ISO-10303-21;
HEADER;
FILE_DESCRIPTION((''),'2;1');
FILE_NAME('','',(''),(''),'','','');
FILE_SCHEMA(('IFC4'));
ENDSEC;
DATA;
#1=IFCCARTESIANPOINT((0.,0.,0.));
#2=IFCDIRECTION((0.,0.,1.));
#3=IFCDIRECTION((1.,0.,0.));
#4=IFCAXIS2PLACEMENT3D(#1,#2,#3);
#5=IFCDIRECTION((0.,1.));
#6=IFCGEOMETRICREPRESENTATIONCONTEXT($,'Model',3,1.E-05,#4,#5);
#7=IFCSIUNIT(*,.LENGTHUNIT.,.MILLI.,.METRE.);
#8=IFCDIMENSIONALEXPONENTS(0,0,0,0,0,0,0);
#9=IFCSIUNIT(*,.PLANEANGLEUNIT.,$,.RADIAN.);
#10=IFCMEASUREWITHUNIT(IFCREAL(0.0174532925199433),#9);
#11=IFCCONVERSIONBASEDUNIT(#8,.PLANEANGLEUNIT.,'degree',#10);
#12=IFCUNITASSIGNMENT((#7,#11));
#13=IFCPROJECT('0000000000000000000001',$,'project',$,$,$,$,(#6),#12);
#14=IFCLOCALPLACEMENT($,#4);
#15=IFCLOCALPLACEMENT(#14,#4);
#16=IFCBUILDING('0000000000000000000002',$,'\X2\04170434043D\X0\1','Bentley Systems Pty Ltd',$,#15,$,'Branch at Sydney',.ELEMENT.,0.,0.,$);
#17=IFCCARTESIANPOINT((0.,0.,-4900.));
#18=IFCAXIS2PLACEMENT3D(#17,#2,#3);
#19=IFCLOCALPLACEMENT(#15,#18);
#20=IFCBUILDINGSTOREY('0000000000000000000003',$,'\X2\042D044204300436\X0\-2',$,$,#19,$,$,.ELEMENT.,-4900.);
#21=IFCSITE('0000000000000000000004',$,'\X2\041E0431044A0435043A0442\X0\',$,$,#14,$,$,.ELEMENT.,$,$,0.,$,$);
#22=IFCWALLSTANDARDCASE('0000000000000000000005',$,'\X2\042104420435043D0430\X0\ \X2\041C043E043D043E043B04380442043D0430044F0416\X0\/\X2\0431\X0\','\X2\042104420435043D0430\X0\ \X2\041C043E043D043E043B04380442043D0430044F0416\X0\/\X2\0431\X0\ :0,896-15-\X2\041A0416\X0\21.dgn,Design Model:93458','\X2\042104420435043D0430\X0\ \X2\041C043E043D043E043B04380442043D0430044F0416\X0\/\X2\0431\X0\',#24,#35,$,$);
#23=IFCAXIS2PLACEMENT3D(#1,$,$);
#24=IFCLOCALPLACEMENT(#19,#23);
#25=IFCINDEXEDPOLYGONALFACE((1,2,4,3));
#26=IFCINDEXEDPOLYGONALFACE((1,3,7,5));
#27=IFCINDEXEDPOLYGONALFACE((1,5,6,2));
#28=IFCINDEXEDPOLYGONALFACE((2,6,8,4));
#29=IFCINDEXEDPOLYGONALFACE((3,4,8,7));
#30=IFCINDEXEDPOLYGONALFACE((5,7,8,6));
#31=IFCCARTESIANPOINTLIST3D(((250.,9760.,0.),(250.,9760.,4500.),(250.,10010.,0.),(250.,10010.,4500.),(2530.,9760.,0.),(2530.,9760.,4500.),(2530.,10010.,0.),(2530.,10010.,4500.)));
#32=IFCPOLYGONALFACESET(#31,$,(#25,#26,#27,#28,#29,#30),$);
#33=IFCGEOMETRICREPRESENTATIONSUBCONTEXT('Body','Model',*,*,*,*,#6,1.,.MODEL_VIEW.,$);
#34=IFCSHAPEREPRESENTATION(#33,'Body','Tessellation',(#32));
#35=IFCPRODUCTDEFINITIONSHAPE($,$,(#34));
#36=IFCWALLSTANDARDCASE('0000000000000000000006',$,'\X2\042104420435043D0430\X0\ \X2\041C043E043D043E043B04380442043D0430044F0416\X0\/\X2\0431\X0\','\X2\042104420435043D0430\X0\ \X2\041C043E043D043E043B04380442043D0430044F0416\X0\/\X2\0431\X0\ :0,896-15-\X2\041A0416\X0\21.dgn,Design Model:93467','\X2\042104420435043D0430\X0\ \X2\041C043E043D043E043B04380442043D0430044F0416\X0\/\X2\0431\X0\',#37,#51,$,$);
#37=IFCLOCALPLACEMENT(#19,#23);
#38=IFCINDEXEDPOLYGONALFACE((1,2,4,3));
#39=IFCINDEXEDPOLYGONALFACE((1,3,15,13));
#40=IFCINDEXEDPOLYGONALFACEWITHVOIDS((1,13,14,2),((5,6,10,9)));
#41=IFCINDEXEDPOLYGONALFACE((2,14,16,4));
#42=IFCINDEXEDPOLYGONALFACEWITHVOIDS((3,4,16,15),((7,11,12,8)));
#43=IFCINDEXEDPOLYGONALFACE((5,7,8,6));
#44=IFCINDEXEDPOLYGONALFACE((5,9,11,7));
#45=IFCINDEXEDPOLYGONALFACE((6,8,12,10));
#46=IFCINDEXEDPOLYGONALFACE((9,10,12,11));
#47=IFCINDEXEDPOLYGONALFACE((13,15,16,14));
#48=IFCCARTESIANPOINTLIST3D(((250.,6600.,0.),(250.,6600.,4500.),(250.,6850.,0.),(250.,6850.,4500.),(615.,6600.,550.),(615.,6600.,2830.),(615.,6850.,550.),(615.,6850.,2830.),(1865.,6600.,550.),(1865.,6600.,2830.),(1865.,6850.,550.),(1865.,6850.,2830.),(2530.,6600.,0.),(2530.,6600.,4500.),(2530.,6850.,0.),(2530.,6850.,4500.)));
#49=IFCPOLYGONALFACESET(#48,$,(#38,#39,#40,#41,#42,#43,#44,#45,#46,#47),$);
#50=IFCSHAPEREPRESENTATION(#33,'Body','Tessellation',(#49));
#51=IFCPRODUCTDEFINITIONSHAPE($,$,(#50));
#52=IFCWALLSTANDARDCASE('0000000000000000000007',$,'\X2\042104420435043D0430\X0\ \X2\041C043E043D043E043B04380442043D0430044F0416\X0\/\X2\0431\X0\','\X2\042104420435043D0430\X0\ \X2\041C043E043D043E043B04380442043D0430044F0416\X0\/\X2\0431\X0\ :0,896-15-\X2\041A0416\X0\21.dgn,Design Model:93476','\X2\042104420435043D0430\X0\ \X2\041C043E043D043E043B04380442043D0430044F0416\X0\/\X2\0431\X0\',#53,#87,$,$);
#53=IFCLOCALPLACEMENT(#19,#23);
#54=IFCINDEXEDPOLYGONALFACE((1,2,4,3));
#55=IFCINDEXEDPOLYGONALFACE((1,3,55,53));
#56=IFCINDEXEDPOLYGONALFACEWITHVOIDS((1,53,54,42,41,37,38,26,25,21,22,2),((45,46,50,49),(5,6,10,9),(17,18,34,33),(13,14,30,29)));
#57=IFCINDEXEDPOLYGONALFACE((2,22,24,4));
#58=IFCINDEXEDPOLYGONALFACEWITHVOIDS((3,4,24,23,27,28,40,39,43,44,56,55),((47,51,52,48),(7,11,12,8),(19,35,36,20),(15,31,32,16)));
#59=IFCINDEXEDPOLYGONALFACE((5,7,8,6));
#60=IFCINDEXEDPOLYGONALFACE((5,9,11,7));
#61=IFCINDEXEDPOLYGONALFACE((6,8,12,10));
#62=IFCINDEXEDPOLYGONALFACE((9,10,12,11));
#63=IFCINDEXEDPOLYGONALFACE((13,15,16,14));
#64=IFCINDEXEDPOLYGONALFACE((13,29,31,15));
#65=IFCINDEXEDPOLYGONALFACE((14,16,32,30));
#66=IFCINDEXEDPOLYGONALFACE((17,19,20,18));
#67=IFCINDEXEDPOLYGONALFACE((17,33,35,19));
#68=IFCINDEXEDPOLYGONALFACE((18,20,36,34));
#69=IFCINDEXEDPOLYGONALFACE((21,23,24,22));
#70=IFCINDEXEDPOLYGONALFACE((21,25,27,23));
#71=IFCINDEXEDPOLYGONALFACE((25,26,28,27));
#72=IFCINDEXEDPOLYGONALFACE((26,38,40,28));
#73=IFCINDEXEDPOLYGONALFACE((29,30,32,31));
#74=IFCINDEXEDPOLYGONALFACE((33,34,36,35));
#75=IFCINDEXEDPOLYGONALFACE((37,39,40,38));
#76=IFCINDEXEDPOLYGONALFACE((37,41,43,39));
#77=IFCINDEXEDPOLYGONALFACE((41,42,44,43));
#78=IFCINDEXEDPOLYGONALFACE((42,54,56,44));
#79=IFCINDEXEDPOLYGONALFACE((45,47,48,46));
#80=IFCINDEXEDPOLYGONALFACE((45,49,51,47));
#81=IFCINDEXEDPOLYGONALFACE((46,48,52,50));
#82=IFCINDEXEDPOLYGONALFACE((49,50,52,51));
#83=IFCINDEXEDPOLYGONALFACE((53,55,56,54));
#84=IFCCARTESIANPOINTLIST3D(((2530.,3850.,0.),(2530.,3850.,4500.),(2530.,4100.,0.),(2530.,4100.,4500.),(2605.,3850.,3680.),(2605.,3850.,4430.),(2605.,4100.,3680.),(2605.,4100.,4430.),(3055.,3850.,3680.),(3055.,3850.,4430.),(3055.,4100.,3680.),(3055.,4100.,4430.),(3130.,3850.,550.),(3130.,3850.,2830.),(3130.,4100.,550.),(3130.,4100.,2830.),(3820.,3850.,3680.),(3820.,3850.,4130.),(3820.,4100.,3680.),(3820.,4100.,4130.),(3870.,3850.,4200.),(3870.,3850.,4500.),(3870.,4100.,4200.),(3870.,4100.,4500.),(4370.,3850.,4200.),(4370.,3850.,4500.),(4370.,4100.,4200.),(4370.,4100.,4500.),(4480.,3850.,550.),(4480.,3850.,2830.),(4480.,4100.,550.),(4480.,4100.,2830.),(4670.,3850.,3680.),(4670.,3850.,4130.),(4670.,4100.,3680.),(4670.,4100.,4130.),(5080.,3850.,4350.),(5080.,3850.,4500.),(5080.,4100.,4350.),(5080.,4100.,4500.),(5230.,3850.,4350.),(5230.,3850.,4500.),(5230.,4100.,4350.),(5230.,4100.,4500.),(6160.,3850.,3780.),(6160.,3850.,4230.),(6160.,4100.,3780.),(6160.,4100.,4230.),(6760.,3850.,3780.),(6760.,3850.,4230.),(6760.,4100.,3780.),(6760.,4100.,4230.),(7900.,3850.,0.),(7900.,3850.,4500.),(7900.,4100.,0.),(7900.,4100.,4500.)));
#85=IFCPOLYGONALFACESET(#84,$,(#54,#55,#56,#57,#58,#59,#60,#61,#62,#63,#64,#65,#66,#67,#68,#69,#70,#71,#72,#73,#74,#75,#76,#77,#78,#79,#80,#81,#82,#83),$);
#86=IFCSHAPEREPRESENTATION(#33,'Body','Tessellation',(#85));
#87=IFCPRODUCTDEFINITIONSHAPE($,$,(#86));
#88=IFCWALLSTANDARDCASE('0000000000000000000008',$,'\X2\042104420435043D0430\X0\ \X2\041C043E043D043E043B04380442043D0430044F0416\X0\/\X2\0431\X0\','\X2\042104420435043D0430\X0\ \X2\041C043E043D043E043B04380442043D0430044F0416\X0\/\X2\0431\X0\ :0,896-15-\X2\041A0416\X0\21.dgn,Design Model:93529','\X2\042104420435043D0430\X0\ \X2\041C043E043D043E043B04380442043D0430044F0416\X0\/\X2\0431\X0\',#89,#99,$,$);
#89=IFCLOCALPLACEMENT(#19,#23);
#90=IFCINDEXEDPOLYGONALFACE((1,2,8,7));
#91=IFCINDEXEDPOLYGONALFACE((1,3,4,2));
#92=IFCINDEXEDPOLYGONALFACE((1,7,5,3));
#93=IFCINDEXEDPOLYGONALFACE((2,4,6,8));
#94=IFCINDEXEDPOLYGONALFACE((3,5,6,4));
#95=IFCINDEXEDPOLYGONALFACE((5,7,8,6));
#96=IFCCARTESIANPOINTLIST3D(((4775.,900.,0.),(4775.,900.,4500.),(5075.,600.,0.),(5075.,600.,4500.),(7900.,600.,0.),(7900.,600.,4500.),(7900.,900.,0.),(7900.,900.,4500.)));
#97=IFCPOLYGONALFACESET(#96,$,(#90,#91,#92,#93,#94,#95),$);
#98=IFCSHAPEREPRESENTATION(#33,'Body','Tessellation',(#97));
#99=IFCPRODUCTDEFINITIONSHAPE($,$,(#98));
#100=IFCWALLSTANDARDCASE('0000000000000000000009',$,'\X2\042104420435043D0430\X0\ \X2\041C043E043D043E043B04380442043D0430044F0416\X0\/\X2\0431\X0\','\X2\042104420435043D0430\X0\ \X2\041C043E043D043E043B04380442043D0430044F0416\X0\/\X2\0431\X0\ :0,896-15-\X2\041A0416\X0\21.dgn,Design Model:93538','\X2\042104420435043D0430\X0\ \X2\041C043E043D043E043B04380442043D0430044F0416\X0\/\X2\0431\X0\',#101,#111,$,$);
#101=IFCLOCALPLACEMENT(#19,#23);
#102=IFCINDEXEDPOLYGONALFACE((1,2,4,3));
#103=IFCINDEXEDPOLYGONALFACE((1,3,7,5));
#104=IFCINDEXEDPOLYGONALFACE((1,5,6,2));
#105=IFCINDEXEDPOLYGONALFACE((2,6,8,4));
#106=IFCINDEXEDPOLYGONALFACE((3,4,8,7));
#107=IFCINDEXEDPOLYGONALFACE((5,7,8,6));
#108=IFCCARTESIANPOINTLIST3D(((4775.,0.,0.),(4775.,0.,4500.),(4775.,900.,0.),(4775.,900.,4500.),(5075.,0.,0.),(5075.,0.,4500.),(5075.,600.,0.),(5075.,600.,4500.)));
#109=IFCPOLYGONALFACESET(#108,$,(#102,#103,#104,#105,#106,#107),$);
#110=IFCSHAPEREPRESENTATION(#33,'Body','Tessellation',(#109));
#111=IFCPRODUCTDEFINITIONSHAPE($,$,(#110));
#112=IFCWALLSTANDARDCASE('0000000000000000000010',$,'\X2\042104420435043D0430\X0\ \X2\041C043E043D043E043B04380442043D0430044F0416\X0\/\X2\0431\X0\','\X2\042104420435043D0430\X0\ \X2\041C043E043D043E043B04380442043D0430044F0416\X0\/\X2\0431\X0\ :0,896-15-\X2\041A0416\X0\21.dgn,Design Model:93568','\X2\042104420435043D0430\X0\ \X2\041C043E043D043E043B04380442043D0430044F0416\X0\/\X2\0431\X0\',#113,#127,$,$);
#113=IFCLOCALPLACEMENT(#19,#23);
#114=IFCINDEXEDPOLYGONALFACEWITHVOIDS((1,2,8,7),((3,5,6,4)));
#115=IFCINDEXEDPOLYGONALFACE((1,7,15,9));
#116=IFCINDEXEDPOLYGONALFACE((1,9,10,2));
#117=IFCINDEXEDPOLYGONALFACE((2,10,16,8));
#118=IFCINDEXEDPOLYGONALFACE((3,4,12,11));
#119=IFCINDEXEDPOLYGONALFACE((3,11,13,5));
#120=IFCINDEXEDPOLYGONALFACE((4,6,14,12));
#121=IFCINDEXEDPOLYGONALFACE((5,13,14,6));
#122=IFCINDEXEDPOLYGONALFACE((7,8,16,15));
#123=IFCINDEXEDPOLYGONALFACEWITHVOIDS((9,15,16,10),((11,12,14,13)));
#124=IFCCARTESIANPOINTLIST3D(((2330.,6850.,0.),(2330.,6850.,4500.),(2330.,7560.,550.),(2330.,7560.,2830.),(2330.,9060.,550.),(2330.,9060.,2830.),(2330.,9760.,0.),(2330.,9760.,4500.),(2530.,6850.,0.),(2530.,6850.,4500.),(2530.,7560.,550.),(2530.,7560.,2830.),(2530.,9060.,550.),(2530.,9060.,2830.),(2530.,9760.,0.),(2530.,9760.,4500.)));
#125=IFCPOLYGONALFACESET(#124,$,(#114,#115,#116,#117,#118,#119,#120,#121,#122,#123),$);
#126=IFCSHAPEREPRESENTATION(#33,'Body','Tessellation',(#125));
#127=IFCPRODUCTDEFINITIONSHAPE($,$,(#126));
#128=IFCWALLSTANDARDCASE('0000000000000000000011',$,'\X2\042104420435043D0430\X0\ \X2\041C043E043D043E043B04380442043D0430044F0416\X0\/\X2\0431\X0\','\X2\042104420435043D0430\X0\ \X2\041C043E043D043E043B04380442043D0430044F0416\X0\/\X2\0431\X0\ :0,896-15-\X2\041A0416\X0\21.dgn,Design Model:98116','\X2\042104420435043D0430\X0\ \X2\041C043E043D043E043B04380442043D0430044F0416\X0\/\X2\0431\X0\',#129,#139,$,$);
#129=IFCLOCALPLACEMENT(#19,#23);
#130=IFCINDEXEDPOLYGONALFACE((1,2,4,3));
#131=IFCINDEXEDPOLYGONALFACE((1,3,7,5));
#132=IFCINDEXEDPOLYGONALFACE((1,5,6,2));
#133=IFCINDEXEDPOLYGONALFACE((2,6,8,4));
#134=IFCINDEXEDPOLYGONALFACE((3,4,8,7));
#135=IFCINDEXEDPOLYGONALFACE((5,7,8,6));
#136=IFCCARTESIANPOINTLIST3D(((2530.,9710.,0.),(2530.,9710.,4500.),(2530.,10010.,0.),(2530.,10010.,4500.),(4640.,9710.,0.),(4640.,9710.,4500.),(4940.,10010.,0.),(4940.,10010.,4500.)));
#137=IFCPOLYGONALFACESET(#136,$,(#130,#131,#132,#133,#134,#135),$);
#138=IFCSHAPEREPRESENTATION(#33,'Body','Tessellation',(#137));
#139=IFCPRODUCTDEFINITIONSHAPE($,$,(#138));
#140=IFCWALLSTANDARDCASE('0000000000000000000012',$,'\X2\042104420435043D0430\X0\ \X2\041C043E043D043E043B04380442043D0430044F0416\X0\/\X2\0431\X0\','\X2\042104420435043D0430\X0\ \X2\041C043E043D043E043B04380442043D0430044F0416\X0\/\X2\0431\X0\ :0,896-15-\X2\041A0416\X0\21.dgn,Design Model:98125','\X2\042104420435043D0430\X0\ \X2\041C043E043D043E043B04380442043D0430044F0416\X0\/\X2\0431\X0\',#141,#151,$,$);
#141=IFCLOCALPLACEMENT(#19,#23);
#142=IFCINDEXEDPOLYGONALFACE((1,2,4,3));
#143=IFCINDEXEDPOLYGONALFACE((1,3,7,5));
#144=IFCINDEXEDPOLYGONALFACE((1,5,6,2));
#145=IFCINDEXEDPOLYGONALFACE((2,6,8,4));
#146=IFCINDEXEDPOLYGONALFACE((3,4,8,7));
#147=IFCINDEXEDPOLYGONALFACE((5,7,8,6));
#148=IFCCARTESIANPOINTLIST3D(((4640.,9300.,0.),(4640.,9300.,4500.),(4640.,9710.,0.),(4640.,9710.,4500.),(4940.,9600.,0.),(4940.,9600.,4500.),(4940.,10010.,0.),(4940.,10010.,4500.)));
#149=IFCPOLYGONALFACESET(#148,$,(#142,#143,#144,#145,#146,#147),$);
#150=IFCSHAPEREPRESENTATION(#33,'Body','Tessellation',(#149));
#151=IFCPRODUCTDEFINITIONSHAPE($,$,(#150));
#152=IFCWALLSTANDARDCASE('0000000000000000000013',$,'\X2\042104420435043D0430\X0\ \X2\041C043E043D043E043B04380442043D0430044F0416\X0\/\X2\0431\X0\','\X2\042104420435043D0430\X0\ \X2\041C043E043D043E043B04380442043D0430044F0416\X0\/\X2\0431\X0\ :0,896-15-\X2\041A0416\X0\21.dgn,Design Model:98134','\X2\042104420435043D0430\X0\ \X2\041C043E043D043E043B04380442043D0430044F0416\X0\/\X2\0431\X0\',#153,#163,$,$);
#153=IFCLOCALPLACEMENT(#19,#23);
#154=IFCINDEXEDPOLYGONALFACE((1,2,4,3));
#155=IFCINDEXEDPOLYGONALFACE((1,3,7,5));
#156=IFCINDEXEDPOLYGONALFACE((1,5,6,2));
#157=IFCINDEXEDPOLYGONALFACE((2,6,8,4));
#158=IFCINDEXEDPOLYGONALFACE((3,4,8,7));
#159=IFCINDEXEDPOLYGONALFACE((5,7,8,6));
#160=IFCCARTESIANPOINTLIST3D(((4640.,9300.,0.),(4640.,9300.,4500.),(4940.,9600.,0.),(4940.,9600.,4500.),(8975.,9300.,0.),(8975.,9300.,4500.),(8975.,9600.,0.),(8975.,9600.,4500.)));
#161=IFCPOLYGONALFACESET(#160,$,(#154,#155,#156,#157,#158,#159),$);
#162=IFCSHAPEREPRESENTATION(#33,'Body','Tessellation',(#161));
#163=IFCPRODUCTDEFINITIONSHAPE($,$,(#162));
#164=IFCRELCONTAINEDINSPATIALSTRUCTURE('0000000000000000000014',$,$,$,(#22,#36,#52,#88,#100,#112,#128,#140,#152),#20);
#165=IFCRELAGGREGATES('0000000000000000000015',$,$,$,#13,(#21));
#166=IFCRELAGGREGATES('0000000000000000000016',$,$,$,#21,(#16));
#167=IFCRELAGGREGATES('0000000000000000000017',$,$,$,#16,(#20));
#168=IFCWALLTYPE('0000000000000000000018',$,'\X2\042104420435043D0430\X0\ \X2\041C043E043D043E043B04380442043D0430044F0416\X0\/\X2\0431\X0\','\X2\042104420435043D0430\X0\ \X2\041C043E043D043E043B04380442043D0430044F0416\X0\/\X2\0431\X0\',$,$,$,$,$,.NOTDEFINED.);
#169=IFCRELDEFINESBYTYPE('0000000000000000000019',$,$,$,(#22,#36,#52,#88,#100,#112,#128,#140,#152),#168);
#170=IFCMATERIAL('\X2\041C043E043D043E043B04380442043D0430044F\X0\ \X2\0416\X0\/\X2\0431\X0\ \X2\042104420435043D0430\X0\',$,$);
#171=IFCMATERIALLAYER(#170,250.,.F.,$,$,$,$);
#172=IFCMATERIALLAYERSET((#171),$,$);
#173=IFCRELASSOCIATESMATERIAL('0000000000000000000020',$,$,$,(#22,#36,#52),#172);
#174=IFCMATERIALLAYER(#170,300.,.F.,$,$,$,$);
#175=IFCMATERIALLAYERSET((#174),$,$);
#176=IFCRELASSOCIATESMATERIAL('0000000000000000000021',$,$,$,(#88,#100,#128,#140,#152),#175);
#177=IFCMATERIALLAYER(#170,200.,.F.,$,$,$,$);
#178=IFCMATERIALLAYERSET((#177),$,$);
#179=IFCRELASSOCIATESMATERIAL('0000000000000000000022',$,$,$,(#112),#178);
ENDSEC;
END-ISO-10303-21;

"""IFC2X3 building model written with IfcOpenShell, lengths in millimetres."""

from ifc_helpers import new_model, entity, si_unit, converted_unit, direction, frame, frame_2d, origin_with_axes, place, context, subcontext, project, spatial, polyline, rectangle, outline, extrude, material, layer, layer_set, layer_usage, type_object, element, save


model = new_model("IFC2X3")

# Units and contexts
model_context = context("Model", 3, precision=1e-05, world=origin_with_axes(), true_north=direction((0.0, 1.0)))
body_context = subcontext(model_context, "Body", "Model", "MODEL_VIEW", scale=1.0)
ifc_project = project(units=[si_unit("LENGTHUNIT", "METRE", prefix="MILLI"), converted_unit("PLANEANGLEUNIT", "degree", entity("IfcReal", 0.0174532925199433), si_unit("PLANEANGLEUNIT", "RADIAN"), dimensions=[0, 0, 0, 0, 0, 0, 0])], contexts=[model_context])

# Site, building, storey
site_placement = place(None, origin_with_axes())
site = spatial("IfcSite", under=ifc_project, at=site_placement, Name="Объект", CompositionType="ELEMENT", RefElevation=0.0)
building_placement = place(site_placement, origin_with_axes())
building = spatial("IfcBuilding", under=site, at=building_placement, Name="Здн1", Description="Bentley Systems Pty Ltd", LongName="Branch at Sydney", CompositionType="ELEMENT", ElevationOfRefHeight=0.0, ElevationOfTerrain=0.0)
storey_placement = place(building_placement, frame((0.0, 0.0, -4900.0), z_axis=(0.0, 0.0, 1.0), x_axis=(1.0, 0.0, 0.0)))
storey = spatial("IfcBuildingStorey", under=building, at=storey_placement, Name="Этаж-2", CompositionType="ELEMENT", Elevation=-4900.0)

# Wall
ifc_material = material(Name="Монолитная Ж/б Стена")
ifc_layer_1 = layer(ifc_material, 250.0, ventilated=False)
ifc_layer_set_1 = layer_set([ifc_layer_1])
ifc_layer_usage_1 = layer_usage(ifc_layer_set_1, "AXIS2", "POSITIVE", 0.0)
wall_type = type_object("IfcWallType", Name="Стена МонолитнаяЖ/б", Description="Стена МонолитнаяЖ/б", PredefinedType="NOTDEFINED")
wall_1_placement = place(storey_placement, frame((2530.0, 10010.0, 0.0), z_axis=(0.0, 0.0, 1.0), x_axis=(-1.0, 0.0, 0.0)))
element("IfcWallStandardCase", 1, at=wall_1_placement, inside=storey, type_object=wall_type, material=ifc_layer_usage_1, Name="Стена МонолитнаяЖ/б", Description="Стена МонолитнаяЖ/б :0,896-15-КЖ21.dgn,Design Model:93458", ObjectType="Стена МонолитнаяЖ/б", context=body_context, shape_type="SweptSolid", body=[
    extrude(rectangle(XDim=2280.0, YDim=250.0, at=frame_2d((1140.0, 125.0), x_axis=(1.0, 0.0))), origin_with_axes(), (0.0, 0.0, 1.0), 4500.0),
])

# Wall, opening
wall_2_placement = place(storey_placement, frame((250.0, 6600.0, 0.0), z_axis=(0.0, 0.0, 1.0), x_axis=(1.0, 0.0, 0.0)))
wall_2 = element("IfcWallStandardCase", 2, at=wall_2_placement, inside=storey, type_object=wall_type, material=ifc_layer_usage_1, Name="Стена МонолитнаяЖ/б", Description="Стена МонолитнаяЖ/б :0,896-15-КЖ21.dgn,Design Model:93467", ObjectType="Стена МонолитнаяЖ/б", context=body_context, shape_type="SweptSolid", body=[
    extrude(rectangle(XDim=2280.0, YDim=250.0, at=frame_2d((1140.0, 125.0), x_axis=(1.0, 0.0))), origin_with_axes(), (0.0, 0.0, 1.0), 4500.0),
])
opening_1_placement = place(wall_2_placement, frame((365.0, 0.0, 550.0), z_axis=(0.0, 0.0, 1.0), x_axis=(1.0, 0.0, 0.0)))
element("IfcOpeningElement", 3, at=opening_1_placement, cuts=wall_2, ObjectType="Opening", context=body_context, shape_type="SweptSolid", body=[
    extrude(rectangle(XDim=2280.0, YDim=1250.0, at=frame_2d((-625.0, 1140.0), x_axis=(0.0, -1.0))), frame((0.0, 0.0, 0.0), z_axis=(0.0, 1.0, 0.0), x_axis=(-1.0, 0.0, 0.0)), (0.0, 0.0, 1.0), 250.0),
])

# Wall, openings
wall_3_placement = place(storey_placement, frame((2530.0, 3850.0, 0.0), z_axis=(0.0, 0.0, 1.0), x_axis=(1.0, 0.0, 0.0)))
wall_3 = element("IfcWallStandardCase", 4, at=wall_3_placement, inside=storey, type_object=wall_type, material=ifc_layer_usage_1, Name="Стена МонолитнаяЖ/б", Description="Стена МонолитнаяЖ/б :0,896-15-КЖ21.dgn,Design Model:93476", ObjectType="Стена МонолитнаяЖ/б", context=body_context, shape_type="SweptSolid", body=[
    extrude(rectangle(XDim=5370.0, YDim=250.0, at=frame_2d((2685.0, 125.0), x_axis=(1.0, 0.0))), origin_with_axes(), (0.0, 0.0, 1.0), 4500.0),
])
opening_2_placement = place(wall_3_placement, frame((600.0, 0.0, 550.0), z_axis=(0.0, 0.0, 1.0), x_axis=(1.0, 0.0, 0.0)))
element("IfcOpeningElement", 5, at=opening_2_placement, cuts=wall_3, ObjectType="Opening", context=body_context, shape_type="SweptSolid", body=[
    extrude(rectangle(XDim=2280.0, YDim=1350.0, at=frame_2d((-675.0, 1140.0), x_axis=(0.0, -1.0))), frame((0.0, 0.0, 0.0), z_axis=(0.0, 1.0, 0.0), x_axis=(-1.0, 0.0, 0.0)), (0.0, 0.0, 1.0), 250.0),
])
opening_3_placement = place(wall_3_placement, frame((75.0, 0.0, 3680.0), z_axis=(0.0, 0.0, 1.0), x_axis=(1.0, 0.0, 0.0)))
element("IfcOpeningElement", 6, at=opening_3_placement, cuts=wall_3, ObjectType="Opening", context=body_context, shape_type="SweptSolid", body=[
    extrude(rectangle(XDim=750.0, YDim=450.0, at=frame_2d((-225.0, 375.0), x_axis=(0.0, -1.0))), frame((0.0, 0.0, 0.0), z_axis=(0.0, 1.0, 0.0), x_axis=(-1.0, 0.0, 0.0)), (0.0, 0.0, 1.0), 250.0),
])
opening_4_placement = place(wall_3_placement, frame((1290.0, 0.0, 3680.0), z_axis=(0.0, 0.0, 1.0), x_axis=(1.0, 0.0, 0.0)))
element("IfcOpeningElement", 7, at=opening_4_placement, cuts=wall_3, ObjectType="Opening", context=body_context, shape_type="SweptSolid", body=[
    extrude(rectangle(XDim=450.0, YDim=850.0, at=frame_2d((-425.0, 225.0), x_axis=(0.0, -1.0))), frame((0.0, 0.0, 0.0), z_axis=(0.0, 1.0, 0.0), x_axis=(-1.0, 0.0, 0.0)), (0.0, 0.0, 1.0), 250.0),
])
opening_5_placement = place(wall_3_placement, frame((1340.0, 0.0, 4200.0), z_axis=(0.0, 0.0, 1.0), x_axis=(1.0, 0.0, 0.0)))
element("IfcOpeningElement", 8, at=opening_5_placement, cuts=wall_3, ObjectType="Opening", context=body_context, shape_type="SweptSolid", body=[
    extrude(rectangle(XDim=300.0, YDim=500.0, at=frame_2d((-250.0, 150.0), x_axis=(0.0, -1.0))), frame((0.0, 0.0, 0.0), z_axis=(0.0, 1.0, 0.0), x_axis=(-1.0, 0.0, 0.0)), (0.0, 0.0, 1.0), 250.0),
])
opening_6_placement = place(wall_3_placement, frame((2550.0, 0.0, 4350.0), z_axis=(0.0, 0.0, 1.0), x_axis=(1.0, 0.0, 0.0)))
element("IfcOpeningElement", 9, at=opening_6_placement, cuts=wall_3, ObjectType="Opening", context=body_context, shape_type="SweptSolid", body=[
    extrude(rectangle(XDim=150.0, YDim=150.0, at=frame_2d((-75.0, 75.0), x_axis=(0.0, -1.0))), frame((0.0, 0.0, 0.0), z_axis=(0.0, 1.0, 0.0), x_axis=(-1.0, 0.0, 0.0)), (0.0, 0.0, 1.0), 250.0),
])
opening_7_placement = place(wall_3_placement, frame((3630.0, 0.0, 3780.0), z_axis=(0.0, 0.0, 1.0), x_axis=(1.0, 0.0, 0.0)))
element("IfcOpeningElement", 10, at=opening_7_placement, cuts=wall_3, ObjectType="Opening", context=body_context, shape_type="SweptSolid", body=[
    extrude(rectangle(XDim=450.0, YDim=600.0, at=frame_2d((-300.0, 225.0), x_axis=(0.0, -1.0))), frame((0.0, 0.0, 0.0), z_axis=(0.0, 1.0, 0.0), x_axis=(-1.0, 0.0, 0.0)), (0.0, 0.0, 1.0), 250.0),
])

# Walls
ifc_layer_2 = layer(ifc_material, 300.0, ventilated=False)
ifc_layer_set_2 = layer_set([ifc_layer_2])
ifc_layer_usage_2 = layer_usage(ifc_layer_set_2, "AXIS2", "POSITIVE", 0.0)
wall_4_placement = place(storey_placement, frame((7900.0, 900.0, 0.0), z_axis=(0.0, 0.0, 1.0), x_axis=(-1.0, 0.0, 0.0)))
element("IfcWallStandardCase", 11, at=wall_4_placement, inside=storey, type_object=wall_type, material=ifc_layer_usage_2, Name="Стена МонолитнаяЖ/б", Description="Стена МонолитнаяЖ/б :0,896-15-КЖ21.dgn,Design Model:93529", ObjectType="Стена МонолитнаяЖ/б", context=body_context, shape_type="SweptSolid", body=[
    extrude(outline(polyline([(2825.0, 300.0), (0.0, 300.0), (0.0, 0.0), (3125.0, 0.0), (2825.0, 300.0)])), origin_with_axes(), (0.0, 0.0, 1.0), 4500.0),
])
wall_5_placement = place(storey_placement, frame((4775.0, 900.0, 0.0), z_axis=(0.0, 0.0, 1.0), x_axis=(0.0, -1.0, 0.0)))
element("IfcWallStandardCase", 12, at=wall_5_placement, inside=storey, type_object=wall_type, material=ifc_layer_usage_2, Name="Стена МонолитнаяЖ/б", Description="Стена МонолитнаяЖ/б :0,896-15-КЖ21.dgn,Design Model:93538", ObjectType="Стена МонолитнаяЖ/б", context=body_context, shape_type="SweptSolid", body=[
    extrude(outline(polyline([(900.0, 300.0), (300.0, 300.0), (0.0, 0.0), (900.0, 0.0), (900.0, 300.0)])), origin_with_axes(), (0.0, 0.0, 1.0), 4500.0),
])

# Wall, opening
ifc_layer_3 = layer(ifc_material, 200.0, ventilated=False)
ifc_layer_set_3 = layer_set([ifc_layer_3])
ifc_layer_usage_3 = layer_usage(ifc_layer_set_3, "AXIS2", "POSITIVE", 0.0)
wall_6_placement = place(storey_placement, frame((2330.0, 9760.0, 0.0), z_axis=(0.0, 0.0, 1.0), x_axis=(0.0, -1.0, 0.0)))
wall_6 = element("IfcWallStandardCase", 13, at=wall_6_placement, inside=storey, type_object=wall_type, material=ifc_layer_usage_3, Name="Стена МонолитнаяЖ/б", Description="Стена МонолитнаяЖ/б :0,896-15-КЖ21.dgn,Design Model:93568", ObjectType="Стена МонолитнаяЖ/б", context=body_context, shape_type="SweptSolid", body=[
    extrude(rectangle(XDim=2910.0, YDim=200.0, at=frame_2d((1455.0, 100.0), x_axis=(-1.0, 0.0))), origin_with_axes(), (0.0, 0.0, 1.0), 4500.0),
])
opening_8_placement = place(wall_6_placement, frame((700.0, 0.0, 550.0), z_axis=(0.0, 0.0, 1.0), x_axis=(1.0, 0.0, 0.0)))
element("IfcOpeningElement", 14, at=opening_8_placement, cuts=wall_6, ObjectType="Opening", context=body_context, shape_type="SweptSolid", body=[
    extrude(rectangle(XDim=2280.0, YDim=1500.0, at=frame_2d((-750.0, 1140.0), x_axis=(0.0, -1.0))), frame((0.0, 0.0, 0.0), z_axis=(0.0, 1.0, 0.0), x_axis=(-1.0, 0.0, 0.0)), (0.0, 0.0, 1.0), 200.0),
])

# Walls
wall_7_placement = place(storey_placement, frame((2530.0, 10010.0, 0.0), z_axis=(0.0, 0.0, 1.0), x_axis=(1.0, 0.0, 0.0)))
element("IfcWallStandardCase", 15, at=wall_7_placement, inside=storey, type_object=wall_type, material=ifc_layer_usage_2, Name="Стена МонолитнаяЖ/б", Description="Стена МонолитнаяЖ/б :0,896-15-КЖ21.dgn,Design Model:98116", ObjectType="Стена МонолитнаяЖ/б", context=body_context, shape_type="SweptSolid", body=[
    extrude(outline(polyline([(2410.0, 0.0), (0.0, 0.0), (0.0, -300.0), (2110.0, -300.0), (2410.0, 0.0)])), origin_with_axes(), (0.0, 0.0, 1.0), 4500.0),
])
wall_8_placement = place(storey_placement, frame((4940.0, 10010.0, 0.0), z_axis=(0.0, 0.0, 1.0), x_axis=(0.0, -1.0, 0.0)))
element("IfcWallStandardCase", 16, at=wall_8_placement, inside=storey, type_object=wall_type, material=ifc_layer_usage_2, Name="Стена МонолитнаяЖ/б", Description="Стена МонолитнаяЖ/б :0,896-15-КЖ21.dgn,Design Model:98125", ObjectType="Стена МонолитнаяЖ/б", context=body_context, shape_type="SweptSolid", body=[
    extrude(outline(polyline([(410.0, 0.0), (0.0, 0.0), (300.0, -300.0), (710.0, -300.0), (410.0, 0.0)])), origin_with_axes(), (0.0, 0.0, 1.0), 4500.0),
])
wall_9_placement = place(storey_placement, frame((4940.0, 9600.0, 0.0), z_axis=(0.0, 0.0, 1.0), x_axis=(1.0, 0.0, 0.0)))
element("IfcWallStandardCase", 17, at=wall_9_placement, inside=storey, type_object=wall_type, material=ifc_layer_usage_2, Name="Стена МонолитнаяЖ/б", Description="Стена МонолитнаяЖ/б :0,896-15-КЖ21.dgn,Design Model:98134", ObjectType="Стена МонолитнаяЖ/б", context=body_context, shape_type="SweptSolid", body=[
    extrude(outline(polyline([(0.0, 0.0), (-300.0, -300.0), (4035.0, -300.0), (4035.0, 0.0), (0.0, 0.0)])), origin_with_axes(), (0.0, 0.0, 1.0), 4500.0),
])

save(model, "model.ifc")
